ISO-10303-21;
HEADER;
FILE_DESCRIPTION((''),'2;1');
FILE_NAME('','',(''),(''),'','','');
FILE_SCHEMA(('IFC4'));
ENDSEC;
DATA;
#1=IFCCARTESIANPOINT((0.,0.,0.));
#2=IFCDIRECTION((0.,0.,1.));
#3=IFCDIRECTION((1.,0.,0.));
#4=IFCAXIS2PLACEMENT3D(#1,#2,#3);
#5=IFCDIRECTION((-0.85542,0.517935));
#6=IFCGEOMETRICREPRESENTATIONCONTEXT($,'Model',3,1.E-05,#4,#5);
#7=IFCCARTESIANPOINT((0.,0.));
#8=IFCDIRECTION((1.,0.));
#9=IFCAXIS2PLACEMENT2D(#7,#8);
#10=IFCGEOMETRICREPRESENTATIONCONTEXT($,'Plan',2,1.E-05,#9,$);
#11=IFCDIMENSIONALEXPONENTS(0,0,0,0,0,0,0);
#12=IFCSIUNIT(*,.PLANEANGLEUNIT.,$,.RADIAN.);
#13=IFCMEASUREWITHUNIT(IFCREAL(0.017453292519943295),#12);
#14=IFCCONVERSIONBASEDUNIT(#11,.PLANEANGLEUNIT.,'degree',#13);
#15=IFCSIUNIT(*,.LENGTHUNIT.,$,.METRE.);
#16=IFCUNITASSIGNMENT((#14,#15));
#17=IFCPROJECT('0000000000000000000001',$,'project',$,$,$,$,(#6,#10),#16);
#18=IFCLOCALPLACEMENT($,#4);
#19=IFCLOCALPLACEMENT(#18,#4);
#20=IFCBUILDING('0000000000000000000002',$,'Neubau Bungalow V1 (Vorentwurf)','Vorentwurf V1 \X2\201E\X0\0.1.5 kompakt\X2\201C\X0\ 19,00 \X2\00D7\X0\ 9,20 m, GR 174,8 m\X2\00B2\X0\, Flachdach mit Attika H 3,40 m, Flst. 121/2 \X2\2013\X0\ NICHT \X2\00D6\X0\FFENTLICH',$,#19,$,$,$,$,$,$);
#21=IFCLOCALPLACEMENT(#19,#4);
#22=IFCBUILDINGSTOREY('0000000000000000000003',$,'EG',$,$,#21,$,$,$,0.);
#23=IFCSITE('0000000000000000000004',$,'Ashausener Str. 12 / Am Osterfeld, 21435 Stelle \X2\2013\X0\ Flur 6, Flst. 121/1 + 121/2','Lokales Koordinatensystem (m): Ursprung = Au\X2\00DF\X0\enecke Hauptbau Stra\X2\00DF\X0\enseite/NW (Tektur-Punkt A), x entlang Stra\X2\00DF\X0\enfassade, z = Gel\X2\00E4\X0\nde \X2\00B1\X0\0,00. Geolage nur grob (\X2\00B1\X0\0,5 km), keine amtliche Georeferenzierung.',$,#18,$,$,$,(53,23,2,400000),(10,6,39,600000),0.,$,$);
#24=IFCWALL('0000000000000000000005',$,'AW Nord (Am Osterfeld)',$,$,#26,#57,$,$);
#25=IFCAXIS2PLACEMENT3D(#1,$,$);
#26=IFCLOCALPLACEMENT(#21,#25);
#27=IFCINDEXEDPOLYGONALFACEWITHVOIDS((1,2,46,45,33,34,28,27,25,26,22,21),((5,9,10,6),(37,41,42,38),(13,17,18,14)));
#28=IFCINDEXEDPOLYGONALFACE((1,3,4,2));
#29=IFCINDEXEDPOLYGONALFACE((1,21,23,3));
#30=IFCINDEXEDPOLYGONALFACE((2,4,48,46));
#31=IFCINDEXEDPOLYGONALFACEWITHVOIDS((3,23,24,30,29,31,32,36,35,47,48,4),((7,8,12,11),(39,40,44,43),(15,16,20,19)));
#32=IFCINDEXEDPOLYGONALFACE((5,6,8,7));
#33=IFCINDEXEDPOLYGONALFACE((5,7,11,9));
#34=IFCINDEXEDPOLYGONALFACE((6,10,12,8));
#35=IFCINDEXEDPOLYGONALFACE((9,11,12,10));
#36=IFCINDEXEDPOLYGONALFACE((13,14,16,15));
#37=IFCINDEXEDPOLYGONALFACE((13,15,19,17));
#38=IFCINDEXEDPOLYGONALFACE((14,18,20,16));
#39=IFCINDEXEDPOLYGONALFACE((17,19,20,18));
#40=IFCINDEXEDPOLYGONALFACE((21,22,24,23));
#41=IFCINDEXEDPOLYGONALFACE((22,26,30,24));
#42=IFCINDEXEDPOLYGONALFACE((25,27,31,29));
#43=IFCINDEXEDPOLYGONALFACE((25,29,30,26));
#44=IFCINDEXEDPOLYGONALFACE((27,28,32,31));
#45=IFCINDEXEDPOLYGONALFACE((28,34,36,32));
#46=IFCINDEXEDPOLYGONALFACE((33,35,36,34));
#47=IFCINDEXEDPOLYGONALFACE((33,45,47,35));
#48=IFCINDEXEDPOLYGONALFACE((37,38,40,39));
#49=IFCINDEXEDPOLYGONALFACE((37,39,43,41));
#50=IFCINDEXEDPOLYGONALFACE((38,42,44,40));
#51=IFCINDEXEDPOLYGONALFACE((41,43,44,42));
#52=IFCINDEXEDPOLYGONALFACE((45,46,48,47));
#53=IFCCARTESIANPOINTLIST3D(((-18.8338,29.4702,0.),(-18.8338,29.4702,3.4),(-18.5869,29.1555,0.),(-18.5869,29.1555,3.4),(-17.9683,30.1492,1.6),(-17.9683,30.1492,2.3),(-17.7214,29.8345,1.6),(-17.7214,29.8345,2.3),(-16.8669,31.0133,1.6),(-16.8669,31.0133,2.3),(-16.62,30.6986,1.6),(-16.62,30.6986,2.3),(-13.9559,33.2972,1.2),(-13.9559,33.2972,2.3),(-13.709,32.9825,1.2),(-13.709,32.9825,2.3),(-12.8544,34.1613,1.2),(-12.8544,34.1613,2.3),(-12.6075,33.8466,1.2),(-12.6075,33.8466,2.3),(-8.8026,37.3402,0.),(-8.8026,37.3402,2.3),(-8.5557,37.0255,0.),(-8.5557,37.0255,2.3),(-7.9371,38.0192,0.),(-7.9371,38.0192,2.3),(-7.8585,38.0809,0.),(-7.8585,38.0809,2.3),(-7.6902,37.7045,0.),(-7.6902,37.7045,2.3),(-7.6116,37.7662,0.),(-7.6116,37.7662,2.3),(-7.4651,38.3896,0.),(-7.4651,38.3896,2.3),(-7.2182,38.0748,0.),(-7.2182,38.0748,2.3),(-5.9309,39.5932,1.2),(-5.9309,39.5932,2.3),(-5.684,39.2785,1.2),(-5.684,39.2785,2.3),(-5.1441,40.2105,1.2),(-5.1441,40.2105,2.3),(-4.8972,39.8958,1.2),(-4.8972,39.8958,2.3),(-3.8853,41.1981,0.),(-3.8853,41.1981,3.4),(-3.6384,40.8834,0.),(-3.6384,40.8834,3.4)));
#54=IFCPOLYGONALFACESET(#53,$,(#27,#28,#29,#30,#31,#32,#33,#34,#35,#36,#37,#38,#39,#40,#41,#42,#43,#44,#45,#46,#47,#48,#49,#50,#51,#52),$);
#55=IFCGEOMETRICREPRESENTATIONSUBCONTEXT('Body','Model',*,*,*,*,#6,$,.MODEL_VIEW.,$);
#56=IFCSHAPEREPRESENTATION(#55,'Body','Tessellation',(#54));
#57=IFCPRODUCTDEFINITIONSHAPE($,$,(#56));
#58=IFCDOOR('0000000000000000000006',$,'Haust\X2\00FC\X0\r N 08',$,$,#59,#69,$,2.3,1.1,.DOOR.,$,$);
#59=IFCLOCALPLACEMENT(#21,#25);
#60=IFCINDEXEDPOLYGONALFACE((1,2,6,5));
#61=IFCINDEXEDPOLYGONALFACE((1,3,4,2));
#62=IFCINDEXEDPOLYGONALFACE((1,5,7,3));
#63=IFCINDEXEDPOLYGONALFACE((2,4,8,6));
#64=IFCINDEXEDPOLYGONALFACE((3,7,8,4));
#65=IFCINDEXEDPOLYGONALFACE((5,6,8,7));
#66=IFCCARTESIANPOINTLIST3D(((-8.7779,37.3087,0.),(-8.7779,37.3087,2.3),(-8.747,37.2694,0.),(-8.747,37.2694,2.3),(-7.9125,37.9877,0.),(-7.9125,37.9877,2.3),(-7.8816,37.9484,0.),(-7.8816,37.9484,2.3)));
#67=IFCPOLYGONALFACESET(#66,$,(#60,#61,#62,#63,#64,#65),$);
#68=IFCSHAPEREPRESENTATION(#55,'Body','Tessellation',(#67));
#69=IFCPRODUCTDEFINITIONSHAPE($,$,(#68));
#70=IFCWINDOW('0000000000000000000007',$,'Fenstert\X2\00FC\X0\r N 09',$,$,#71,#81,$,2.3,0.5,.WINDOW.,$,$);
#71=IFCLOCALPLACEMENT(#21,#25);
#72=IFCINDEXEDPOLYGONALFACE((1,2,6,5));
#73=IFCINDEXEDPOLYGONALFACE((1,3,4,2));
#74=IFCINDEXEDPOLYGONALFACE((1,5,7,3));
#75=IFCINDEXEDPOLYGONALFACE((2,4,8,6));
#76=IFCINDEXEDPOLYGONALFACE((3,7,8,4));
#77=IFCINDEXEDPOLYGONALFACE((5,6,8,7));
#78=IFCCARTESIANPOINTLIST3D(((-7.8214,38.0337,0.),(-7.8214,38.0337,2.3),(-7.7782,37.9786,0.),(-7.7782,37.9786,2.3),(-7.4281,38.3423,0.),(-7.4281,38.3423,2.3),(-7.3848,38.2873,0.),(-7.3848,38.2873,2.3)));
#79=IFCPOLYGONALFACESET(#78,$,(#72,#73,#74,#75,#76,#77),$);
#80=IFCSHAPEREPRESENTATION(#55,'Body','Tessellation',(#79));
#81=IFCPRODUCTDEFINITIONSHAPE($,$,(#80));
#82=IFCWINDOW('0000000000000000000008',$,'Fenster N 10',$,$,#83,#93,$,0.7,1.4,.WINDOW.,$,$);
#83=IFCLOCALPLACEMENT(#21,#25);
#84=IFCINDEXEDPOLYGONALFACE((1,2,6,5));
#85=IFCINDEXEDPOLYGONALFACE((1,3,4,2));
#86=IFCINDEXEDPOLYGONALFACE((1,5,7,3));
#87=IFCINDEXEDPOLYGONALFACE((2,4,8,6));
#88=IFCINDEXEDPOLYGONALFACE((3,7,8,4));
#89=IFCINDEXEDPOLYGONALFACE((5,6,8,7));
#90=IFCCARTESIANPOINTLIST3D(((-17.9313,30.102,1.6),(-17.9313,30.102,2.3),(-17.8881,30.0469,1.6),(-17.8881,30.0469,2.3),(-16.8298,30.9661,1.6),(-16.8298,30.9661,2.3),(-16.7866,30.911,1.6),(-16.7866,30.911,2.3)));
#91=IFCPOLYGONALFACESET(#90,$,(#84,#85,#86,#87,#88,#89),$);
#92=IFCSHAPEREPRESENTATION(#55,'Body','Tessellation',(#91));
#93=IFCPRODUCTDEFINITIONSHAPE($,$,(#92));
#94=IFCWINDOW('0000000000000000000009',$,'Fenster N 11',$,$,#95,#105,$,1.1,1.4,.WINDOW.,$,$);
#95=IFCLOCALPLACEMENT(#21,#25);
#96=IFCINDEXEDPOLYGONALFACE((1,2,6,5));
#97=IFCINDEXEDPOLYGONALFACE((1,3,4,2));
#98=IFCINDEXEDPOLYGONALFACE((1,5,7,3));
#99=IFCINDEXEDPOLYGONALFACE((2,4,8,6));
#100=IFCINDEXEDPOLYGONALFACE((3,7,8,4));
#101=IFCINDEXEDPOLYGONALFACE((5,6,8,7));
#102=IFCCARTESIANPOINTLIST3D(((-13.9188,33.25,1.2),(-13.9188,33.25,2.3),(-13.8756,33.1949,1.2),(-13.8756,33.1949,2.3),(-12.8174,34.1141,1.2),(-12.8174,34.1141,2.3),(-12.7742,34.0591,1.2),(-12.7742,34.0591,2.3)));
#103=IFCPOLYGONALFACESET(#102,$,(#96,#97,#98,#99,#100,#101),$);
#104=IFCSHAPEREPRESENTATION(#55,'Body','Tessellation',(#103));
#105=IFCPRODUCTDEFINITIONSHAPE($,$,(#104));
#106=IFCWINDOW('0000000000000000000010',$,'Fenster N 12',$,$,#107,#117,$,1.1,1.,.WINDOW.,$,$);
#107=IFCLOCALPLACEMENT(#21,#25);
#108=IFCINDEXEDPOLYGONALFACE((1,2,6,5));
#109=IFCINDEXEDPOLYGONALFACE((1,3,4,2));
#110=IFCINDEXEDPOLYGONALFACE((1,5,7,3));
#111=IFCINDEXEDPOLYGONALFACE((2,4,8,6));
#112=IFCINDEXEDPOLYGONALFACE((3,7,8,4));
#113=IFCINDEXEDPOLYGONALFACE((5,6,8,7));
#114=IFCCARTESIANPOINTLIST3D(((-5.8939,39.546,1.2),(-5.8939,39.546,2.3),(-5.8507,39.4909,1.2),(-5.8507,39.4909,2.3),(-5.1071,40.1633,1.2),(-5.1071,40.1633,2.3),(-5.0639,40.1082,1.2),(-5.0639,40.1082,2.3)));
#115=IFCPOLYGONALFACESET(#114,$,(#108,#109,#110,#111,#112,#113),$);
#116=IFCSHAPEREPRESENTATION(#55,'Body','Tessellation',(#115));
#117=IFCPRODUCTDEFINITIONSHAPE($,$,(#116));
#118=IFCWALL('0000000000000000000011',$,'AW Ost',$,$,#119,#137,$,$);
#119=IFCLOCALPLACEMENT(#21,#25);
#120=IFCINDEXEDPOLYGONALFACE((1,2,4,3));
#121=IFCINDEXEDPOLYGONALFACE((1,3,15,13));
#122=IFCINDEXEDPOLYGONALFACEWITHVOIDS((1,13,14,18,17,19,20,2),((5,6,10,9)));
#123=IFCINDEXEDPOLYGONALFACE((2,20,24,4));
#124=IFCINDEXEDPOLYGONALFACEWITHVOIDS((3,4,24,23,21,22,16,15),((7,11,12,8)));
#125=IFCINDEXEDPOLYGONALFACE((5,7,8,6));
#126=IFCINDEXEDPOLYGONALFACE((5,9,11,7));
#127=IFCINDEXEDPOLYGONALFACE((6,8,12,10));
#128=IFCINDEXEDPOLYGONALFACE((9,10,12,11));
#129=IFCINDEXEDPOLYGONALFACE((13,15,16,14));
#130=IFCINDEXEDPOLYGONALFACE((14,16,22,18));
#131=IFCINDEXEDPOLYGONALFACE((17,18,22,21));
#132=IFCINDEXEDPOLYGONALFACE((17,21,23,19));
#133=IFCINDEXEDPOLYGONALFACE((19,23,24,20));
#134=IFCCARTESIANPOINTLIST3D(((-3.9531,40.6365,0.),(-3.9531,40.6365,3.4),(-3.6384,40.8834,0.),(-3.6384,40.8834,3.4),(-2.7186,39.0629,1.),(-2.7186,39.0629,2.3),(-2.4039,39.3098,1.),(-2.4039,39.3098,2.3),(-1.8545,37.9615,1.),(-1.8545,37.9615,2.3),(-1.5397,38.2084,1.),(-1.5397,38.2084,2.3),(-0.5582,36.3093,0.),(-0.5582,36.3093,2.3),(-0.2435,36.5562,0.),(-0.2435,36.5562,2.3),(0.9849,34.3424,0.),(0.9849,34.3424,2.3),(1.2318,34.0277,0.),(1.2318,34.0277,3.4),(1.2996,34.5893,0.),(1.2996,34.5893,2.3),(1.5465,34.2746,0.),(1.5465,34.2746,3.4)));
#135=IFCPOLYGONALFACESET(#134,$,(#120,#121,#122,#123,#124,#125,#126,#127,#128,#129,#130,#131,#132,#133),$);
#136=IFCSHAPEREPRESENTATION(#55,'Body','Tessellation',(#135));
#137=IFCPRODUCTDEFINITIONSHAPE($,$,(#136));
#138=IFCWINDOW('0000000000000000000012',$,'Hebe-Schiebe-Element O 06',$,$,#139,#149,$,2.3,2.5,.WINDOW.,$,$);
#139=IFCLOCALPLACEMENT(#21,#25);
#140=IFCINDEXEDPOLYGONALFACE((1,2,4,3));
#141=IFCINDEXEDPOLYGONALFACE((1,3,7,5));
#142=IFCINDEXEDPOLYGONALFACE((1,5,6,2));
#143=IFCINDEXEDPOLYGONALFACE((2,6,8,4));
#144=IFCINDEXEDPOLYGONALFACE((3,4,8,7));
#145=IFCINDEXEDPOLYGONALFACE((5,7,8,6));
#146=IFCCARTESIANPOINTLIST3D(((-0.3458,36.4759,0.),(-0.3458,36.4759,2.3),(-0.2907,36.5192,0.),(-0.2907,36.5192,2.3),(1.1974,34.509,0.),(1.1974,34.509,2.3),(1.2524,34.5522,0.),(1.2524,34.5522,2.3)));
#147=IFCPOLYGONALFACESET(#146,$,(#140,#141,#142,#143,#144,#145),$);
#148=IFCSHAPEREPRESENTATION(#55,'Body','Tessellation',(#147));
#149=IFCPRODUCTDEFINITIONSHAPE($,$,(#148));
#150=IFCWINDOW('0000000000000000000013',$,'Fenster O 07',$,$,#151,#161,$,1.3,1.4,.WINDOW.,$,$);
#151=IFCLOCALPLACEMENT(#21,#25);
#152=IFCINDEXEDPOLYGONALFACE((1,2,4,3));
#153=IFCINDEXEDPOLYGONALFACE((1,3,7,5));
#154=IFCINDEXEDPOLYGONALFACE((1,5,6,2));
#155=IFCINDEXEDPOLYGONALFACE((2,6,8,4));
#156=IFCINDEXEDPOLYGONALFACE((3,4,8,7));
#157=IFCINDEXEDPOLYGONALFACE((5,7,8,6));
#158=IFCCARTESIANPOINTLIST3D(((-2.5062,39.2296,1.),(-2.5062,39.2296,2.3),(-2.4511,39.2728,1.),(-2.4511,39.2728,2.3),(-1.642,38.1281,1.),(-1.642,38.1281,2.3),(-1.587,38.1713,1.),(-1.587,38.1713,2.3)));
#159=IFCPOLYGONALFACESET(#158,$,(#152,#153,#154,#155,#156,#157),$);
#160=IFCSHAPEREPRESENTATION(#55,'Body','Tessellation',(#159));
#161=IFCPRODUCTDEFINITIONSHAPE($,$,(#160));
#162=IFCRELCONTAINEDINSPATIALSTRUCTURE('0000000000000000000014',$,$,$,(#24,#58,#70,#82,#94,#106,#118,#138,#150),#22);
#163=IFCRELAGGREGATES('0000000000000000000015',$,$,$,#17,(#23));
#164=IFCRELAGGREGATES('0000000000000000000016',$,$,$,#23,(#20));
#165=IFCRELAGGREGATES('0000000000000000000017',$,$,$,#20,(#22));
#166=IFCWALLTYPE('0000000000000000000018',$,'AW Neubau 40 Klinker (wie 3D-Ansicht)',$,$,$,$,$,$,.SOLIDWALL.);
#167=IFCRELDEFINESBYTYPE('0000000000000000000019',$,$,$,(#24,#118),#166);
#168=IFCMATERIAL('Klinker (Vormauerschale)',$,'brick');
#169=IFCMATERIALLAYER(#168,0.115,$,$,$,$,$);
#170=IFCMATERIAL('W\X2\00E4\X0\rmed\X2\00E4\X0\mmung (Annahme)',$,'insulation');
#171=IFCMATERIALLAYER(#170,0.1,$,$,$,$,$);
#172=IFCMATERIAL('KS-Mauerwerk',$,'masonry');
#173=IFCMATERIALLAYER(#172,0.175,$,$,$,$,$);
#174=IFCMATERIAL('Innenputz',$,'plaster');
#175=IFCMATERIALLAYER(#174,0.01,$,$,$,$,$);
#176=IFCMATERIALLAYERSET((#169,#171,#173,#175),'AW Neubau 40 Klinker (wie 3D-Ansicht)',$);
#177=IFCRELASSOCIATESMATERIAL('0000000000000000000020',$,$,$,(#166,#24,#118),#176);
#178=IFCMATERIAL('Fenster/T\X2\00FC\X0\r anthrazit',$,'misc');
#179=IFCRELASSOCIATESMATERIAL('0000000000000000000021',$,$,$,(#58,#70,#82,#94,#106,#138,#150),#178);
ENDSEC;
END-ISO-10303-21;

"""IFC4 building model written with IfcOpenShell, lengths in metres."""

from ifc_helpers import new_model, entity, si_unit, converted_unit, direction, frame, origin_with_axes, origin_2d_with_axis, place, context, subcontext, project, spatial, indexed_curve, outline, extrude, material, layer, layer_set, layer_usage, type_object, element, fill, save


model = new_model("IFC4")

# Units and contexts
model_context = context("Model", 3, precision=1e-05, world=origin_with_axes(), true_north=direction((-0.85542, 0.517935)))
plan_context = context("Plan", 2, precision=1e-05, world=origin_2d_with_axis())
body_context = subcontext(model_context, "Body", "Model", "MODEL_VIEW")
ifc_project = project(units=[converted_unit("PLANEANGLEUNIT", "degree", entity("IfcReal", 0.017453292519943295), si_unit("PLANEANGLEUNIT", "RADIAN"), dimensions=[0, 0, 0, 0, 0, 0, 0]), si_unit("LENGTHUNIT", "METRE")], contexts=[model_context, plan_context])

# Site, building, storey
site_placement = place(None, origin_with_axes())
site = spatial("IfcSite", under=ifc_project, at=site_placement, Name="Ashausener Str. 12 / Am Osterfeld, 21435 Stelle – Flur 6, Flst. 121/1 + 121/2", Description="Lokales Koordinatensystem (m): Ursprung = Außenecke Hauptbau Straßenseite/NW (Tektur-Punkt A), x entlang Straßenfassade, z = Gelände ±0,00. Geolage nur grob (±0,5 km), keine amtliche Georeferenzierung.", RefLatitude=(53, 23, 2, 400000), RefLongitude=(10, 6, 39, 600000), RefElevation=0.0)
building_placement = place(site_placement, origin_with_axes())
building = spatial("IfcBuilding", under=site, at=building_placement, Name="Neubau Bungalow V1 (Vorentwurf)", Description="Vorentwurf V1 „0.1.5 kompakt“ 19,00 × 9,20 m, GR 174,8 m², Flachdach mit Attika H 3,40 m, Flst. 121/2 – NICHT ÖFFENTLICH")
storey_placement = place(building_placement, origin_with_axes())
storey = spatial("IfcBuildingStorey", under=building, at=storey_placement, Name="EG", Elevation=0.0)

# Wall, openings, door, windows
ifc_material_1 = material(Name="Klinker (Vormauerschale)", Category="brick")
ifc_layer_1 = layer(ifc_material_1, 0.115)
ifc_material_2 = material(Name="Wärmedämmung (Annahme)", Category="insulation")
ifc_layer_2 = layer(ifc_material_2, 0.1)
ifc_material_3 = material(Name="KS-Mauerwerk", Category="masonry")
ifc_layer_3 = layer(ifc_material_3, 0.175)
ifc_material_4 = material(Name="Innenputz", Category="plaster")
ifc_layer_4 = layer(ifc_material_4, 0.01)
ifc_layer_set_1 = layer_set([ifc_layer_1, ifc_layer_2, ifc_layer_3, ifc_layer_4], Name="AW Neubau 40 Klinker (wie 3D-Ansicht)")
ifc_layer_usage_1 = layer_usage(ifc_layer_set_1, "AXIS2", "POSITIVE", 0.0)
wall_type_1 = type_object("IfcWallType", Name="AW Neubau 40 Klinker (wie 3D-Ansicht)", PredefinedType="SOLIDWALL", material=ifc_layer_set_1)
wall_1_placement = place(storey_placement, frame((-3.8853, 41.1981, 0.0), z_axis=(0.0, 0.0, 1.0), x_axis=(-0.786761, -0.617258, 0.0)))
wall_1 = element("IfcWall", 1, at=wall_1_placement, inside=storey, type_object=wall_type_1, material=ifc_layer_usage_1, Name="AW Nord (Am Osterfeld)", context=body_context, shape_type="SweptSolid", body=[
    extrude(outline(indexed_curve([(0.0, 0.0), (0.0, 0.4), (19.0, 0.4), (19.0, 0.0), (0.0, 0.0)], self_intersect=False)), origin_with_axes(), (0.0, 0.0, 1.0), 3.4),
])
opening_1_placement = place(wall_1_placement, frame((5.15, -0.1, 0.0), z_axis=(0.0, 0.0, 1.0), x_axis=(1.0, 0.0, 0.0)))
opening_1 = element("IfcOpeningElement", 2, at=opening_1_placement, cuts=wall_1, context=body_context, shape_type="SweptSolid", body=[
    extrude(outline(indexed_curve([(0.0, 0.0), (0.0, 0.6), (1.1, 0.6), (1.1, 0.0), (0.0, 0.0)], self_intersect=False)), origin_with_axes(), (0.0, 0.0, 1.0), 2.3),
])
opening_2_placement = place(wall_1_placement, frame((4.55, -0.1, 0.0), z_axis=(0.0, 0.0, 1.0), x_axis=(1.0, 0.0, 0.0)))
opening_2 = element("IfcOpeningElement", 3, at=opening_2_placement, cuts=wall_1, context=body_context, shape_type="SweptSolid", body=[
    extrude(outline(indexed_curve([(0.0, 0.0), (0.0, 0.6), (0.5, 0.6), (0.5, 0.0), (0.0, 0.0)], self_intersect=False)), origin_with_axes(), (0.0, 0.0, 1.0), 2.3),
])
opening_3_placement = place(wall_1_placement, frame((16.5, -0.1, 1.6), z_axis=(0.0, 0.0, 1.0), x_axis=(1.0, 0.0, 0.0)))
opening_3 = element("IfcOpeningElement", 4, at=opening_3_placement, cuts=wall_1, context=body_context, shape_type="SweptSolid", body=[
    extrude(outline(indexed_curve([(0.0, 0.0), (0.0, 0.6), (1.4, 0.6), (1.4, 0.0), (0.0, 0.0)], self_intersect=False)), origin_with_axes(), (0.0, 0.0, 1.0), 0.7),
])
opening_4_placement = place(wall_1_placement, frame((11.4, -0.1, 1.2), z_axis=(0.0, 0.0, 1.0), x_axis=(1.0, 0.0, 0.0)))
opening_4 = element("IfcOpeningElement", 5, at=opening_4_placement, cuts=wall_1, context=body_context, shape_type="SweptSolid", body=[
    extrude(outline(indexed_curve([(0.0, 0.0), (0.0, 0.6), (1.4, 0.6), (1.4, 0.0), (0.0, 0.0)], self_intersect=False)), origin_with_axes(), (0.0, 0.0, 1.0), 1.1),
])
opening_5_placement = place(wall_1_placement, frame((1.6, -0.1, 1.2), z_axis=(0.0, 0.0, 1.0), x_axis=(1.0, 0.0, 0.0)))
opening_5 = element("IfcOpeningElement", 6, at=opening_5_placement, cuts=wall_1, context=body_context, shape_type="SweptSolid", body=[
    extrude(outline(indexed_curve([(0.0, 0.0), (0.0, 0.6), (1.0, 0.6), (1.0, 0.0), (0.0, 0.0)], self_intersect=False)), origin_with_axes(), (0.0, 0.0, 1.0), 1.1),
])
ifc_material_5 = material(Name="Fenster/Tür anthrazit", Category="misc")
door_placement = place(storey_placement, frame((-7.9125, 37.9877, 0.0), z_axis=(0.0, 0.0, 1.0), x_axis=(-0.786761, -0.617258, 0.0)))
door = element("IfcDoor", 7, at=door_placement, inside=storey, material=ifc_material_5, Name="Haustür N 08", OverallHeight=2.3, OverallWidth=1.1, PredefinedType="DOOR", context=body_context, shape_type="SweptSolid", body=[
    extrude(outline(indexed_curve([(0.0, 0.0), (0.0, 0.05), (1.1, 0.05), (1.1, 0.0), (0.0, 0.0)], self_intersect=False)), origin_with_axes(), (0.0, 0.0, 1.0), 2.3),
])
fill(opening_1, door)
window_1_placement = place(storey_placement, frame((-7.4281, 38.3423, 0.0), z_axis=(0.0, 0.0, 1.0), x_axis=(-0.786761, -0.617258, 0.0)))
window_1 = element("IfcWindow", 8, at=window_1_placement, inside=storey, material=ifc_material_5, Name="Fenstertür N 09", OverallHeight=2.3, OverallWidth=0.5, PredefinedType="WINDOW", context=body_context, shape_type="SweptSolid", body=[
    extrude(outline(indexed_curve([(0.0, 0.0), (0.0, 0.07), (0.5, 0.07), (0.5, 0.0), (0.0, 0.0)], self_intersect=False)), origin_with_axes(), (0.0, 0.0, 1.0), 2.3),
])
fill(opening_2, window_1)
window_2_placement = place(storey_placement, frame((-16.8298, 30.9661, 1.6), z_axis=(0.0, 0.0, 1.0), x_axis=(-0.786761, -0.617258, 0.0)))
window_2 = element("IfcWindow", 9, at=window_2_placement, inside=storey, material=ifc_material_5, Name="Fenster N 10", OverallHeight=0.7, OverallWidth=1.4, PredefinedType="WINDOW", context=body_context, shape_type="SweptSolid", body=[
    extrude(outline(indexed_curve([(0.0, 0.0), (0.0, 0.07), (1.4, 0.07), (1.4, 0.0), (0.0, 0.0)], self_intersect=False)), origin_with_axes(), (0.0, 0.0, 1.0), 0.7),
])
fill(opening_3, window_2)
window_3_placement = place(storey_placement, frame((-12.8174, 34.1141, 1.2), z_axis=(0.0, 0.0, 1.0), x_axis=(-0.786761, -0.617258, 0.0)))
window_3 = element("IfcWindow", 10, at=window_3_placement, inside=storey, material=ifc_material_5, Name="Fenster N 11", OverallHeight=1.1, OverallWidth=1.4, PredefinedType="WINDOW", context=body_context, shape_type="SweptSolid", body=[
    extrude(outline(indexed_curve([(0.0, 0.0), (0.0, 0.07), (1.4, 0.07), (1.4, 0.0), (0.0, 0.0)], self_intersect=False)), origin_with_axes(), (0.0, 0.0, 1.0), 1.1),
])
fill(opening_4, window_3)
window_4_placement = place(storey_placement, frame((-5.1071, 40.1633, 1.2), z_axis=(0.0, 0.0, 1.0), x_axis=(-0.786761, -0.617258, 0.0)))
window_4 = element("IfcWindow", 11, at=window_4_placement, inside=storey, material=ifc_material_5, Name="Fenster N 12", OverallHeight=1.1, OverallWidth=1.0, PredefinedType="WINDOW", context=body_context, shape_type="SweptSolid", body=[
    extrude(outline(indexed_curve([(0.0, 0.0), (0.0, 0.07), (1.0, 0.07), (1.0, 0.0), (0.0, 0.0)], self_intersect=False)), origin_with_axes(), (0.0, 0.0, 1.0), 1.1),
])
fill(opening_5, window_4)

# Wall, openings, windows
ifc_layer_usage_2 = layer_usage(ifc_layer_set_1, "AXIS2", "POSITIVE", 0.0)
wall_2_placement = place(storey_placement, frame((1.5465, 34.2746, 0.0), z_axis=(0.0, 0.0, 1.0), x_axis=(-0.617258, 0.786761, 0.0)))
wall_2 = element("IfcWall", 12, at=wall_2_placement, inside=storey, type_object=wall_type_1, material=ifc_layer_usage_2, Name="AW Ost", context=body_context, shape_type="SweptSolid", body=[
    extrude(outline(indexed_curve([(0.0, 0.0), (0.0, 0.4), (8.4, 0.4), (8.4, 0.0), (0.0, 0.0)], self_intersect=False)), origin_with_axes(), (0.0, 0.0, 1.0), 3.4),
])
opening_6_placement = place(wall_2_placement, frame((0.4, -0.1, 0.0), z_axis=(0.0, 0.0, 1.0), x_axis=(1.0, 0.0, 0.0)))
opening_6 = element("IfcOpeningElement", 13, at=opening_6_placement, cuts=wall_2, context=body_context, shape_type="SweptSolid", body=[
    extrude(outline(indexed_curve([(0.0, 0.0), (0.0, 0.6), (2.5, 0.6), (2.5, 0.0), (0.0, 0.0)], self_intersect=False)), origin_with_axes(), (0.0, 0.0, 1.0), 2.3),
])
opening_7_placement = place(wall_2_placement, frame((5.0, -0.1, 1.0), z_axis=(0.0, 0.0, 1.0), x_axis=(1.0, 0.0, 0.0)))
opening_7 = element("IfcOpeningElement", 14, at=opening_7_placement, cuts=wall_2, context=body_context, shape_type="SweptSolid", body=[
    extrude(outline(indexed_curve([(0.0, 0.0), (0.0, 0.6), (1.4, 0.6), (1.4, 0.0), (0.0, 0.0)], self_intersect=False)), origin_with_axes(), (0.0, 0.0, 1.0), 1.3),
])
window_5_placement = place(storey_placement, frame((1.2524, 34.5522, 0.0), z_axis=(0.0, 0.0, 1.0), x_axis=(-0.617258, 0.786761, 0.0)))
window_5 = element("IfcWindow", 15, at=window_5_placement, inside=storey, material=ifc_material_5, Name="Hebe-Schiebe-Element O 06", OverallHeight=2.3, OverallWidth=2.5, PredefinedType="WINDOW", context=body_context, shape_type="SweptSolid", body=[
    extrude(outline(indexed_curve([(0.0, 0.0), (0.0, 0.07), (2.5, 0.07), (2.5, 0.0), (0.0, 0.0)], self_intersect=False)), origin_with_axes(), (0.0, 0.0, 1.0), 2.3),
])
fill(opening_6, window_5)
window_6_placement = place(storey_placement, frame((-1.587, 38.1713, 1.0), z_axis=(0.0, 0.0, 1.0), x_axis=(-0.617258, 0.786761, 0.0)))
window_6 = element("IfcWindow", 16, at=window_6_placement, inside=storey, material=ifc_material_5, Name="Fenster O 07", OverallHeight=1.3, OverallWidth=1.4, PredefinedType="WINDOW", context=body_context, shape_type="SweptSolid", body=[
    extrude(outline(indexed_curve([(0.0, 0.0), (0.0, 0.07), (1.4, 0.07), (1.4, 0.0), (0.0, 0.0)], self_intersect=False)), origin_with_axes(), (0.0, 0.0, 1.0), 1.3),
])
fill(opening_7, window_6)

save(model, "model.ifc")
